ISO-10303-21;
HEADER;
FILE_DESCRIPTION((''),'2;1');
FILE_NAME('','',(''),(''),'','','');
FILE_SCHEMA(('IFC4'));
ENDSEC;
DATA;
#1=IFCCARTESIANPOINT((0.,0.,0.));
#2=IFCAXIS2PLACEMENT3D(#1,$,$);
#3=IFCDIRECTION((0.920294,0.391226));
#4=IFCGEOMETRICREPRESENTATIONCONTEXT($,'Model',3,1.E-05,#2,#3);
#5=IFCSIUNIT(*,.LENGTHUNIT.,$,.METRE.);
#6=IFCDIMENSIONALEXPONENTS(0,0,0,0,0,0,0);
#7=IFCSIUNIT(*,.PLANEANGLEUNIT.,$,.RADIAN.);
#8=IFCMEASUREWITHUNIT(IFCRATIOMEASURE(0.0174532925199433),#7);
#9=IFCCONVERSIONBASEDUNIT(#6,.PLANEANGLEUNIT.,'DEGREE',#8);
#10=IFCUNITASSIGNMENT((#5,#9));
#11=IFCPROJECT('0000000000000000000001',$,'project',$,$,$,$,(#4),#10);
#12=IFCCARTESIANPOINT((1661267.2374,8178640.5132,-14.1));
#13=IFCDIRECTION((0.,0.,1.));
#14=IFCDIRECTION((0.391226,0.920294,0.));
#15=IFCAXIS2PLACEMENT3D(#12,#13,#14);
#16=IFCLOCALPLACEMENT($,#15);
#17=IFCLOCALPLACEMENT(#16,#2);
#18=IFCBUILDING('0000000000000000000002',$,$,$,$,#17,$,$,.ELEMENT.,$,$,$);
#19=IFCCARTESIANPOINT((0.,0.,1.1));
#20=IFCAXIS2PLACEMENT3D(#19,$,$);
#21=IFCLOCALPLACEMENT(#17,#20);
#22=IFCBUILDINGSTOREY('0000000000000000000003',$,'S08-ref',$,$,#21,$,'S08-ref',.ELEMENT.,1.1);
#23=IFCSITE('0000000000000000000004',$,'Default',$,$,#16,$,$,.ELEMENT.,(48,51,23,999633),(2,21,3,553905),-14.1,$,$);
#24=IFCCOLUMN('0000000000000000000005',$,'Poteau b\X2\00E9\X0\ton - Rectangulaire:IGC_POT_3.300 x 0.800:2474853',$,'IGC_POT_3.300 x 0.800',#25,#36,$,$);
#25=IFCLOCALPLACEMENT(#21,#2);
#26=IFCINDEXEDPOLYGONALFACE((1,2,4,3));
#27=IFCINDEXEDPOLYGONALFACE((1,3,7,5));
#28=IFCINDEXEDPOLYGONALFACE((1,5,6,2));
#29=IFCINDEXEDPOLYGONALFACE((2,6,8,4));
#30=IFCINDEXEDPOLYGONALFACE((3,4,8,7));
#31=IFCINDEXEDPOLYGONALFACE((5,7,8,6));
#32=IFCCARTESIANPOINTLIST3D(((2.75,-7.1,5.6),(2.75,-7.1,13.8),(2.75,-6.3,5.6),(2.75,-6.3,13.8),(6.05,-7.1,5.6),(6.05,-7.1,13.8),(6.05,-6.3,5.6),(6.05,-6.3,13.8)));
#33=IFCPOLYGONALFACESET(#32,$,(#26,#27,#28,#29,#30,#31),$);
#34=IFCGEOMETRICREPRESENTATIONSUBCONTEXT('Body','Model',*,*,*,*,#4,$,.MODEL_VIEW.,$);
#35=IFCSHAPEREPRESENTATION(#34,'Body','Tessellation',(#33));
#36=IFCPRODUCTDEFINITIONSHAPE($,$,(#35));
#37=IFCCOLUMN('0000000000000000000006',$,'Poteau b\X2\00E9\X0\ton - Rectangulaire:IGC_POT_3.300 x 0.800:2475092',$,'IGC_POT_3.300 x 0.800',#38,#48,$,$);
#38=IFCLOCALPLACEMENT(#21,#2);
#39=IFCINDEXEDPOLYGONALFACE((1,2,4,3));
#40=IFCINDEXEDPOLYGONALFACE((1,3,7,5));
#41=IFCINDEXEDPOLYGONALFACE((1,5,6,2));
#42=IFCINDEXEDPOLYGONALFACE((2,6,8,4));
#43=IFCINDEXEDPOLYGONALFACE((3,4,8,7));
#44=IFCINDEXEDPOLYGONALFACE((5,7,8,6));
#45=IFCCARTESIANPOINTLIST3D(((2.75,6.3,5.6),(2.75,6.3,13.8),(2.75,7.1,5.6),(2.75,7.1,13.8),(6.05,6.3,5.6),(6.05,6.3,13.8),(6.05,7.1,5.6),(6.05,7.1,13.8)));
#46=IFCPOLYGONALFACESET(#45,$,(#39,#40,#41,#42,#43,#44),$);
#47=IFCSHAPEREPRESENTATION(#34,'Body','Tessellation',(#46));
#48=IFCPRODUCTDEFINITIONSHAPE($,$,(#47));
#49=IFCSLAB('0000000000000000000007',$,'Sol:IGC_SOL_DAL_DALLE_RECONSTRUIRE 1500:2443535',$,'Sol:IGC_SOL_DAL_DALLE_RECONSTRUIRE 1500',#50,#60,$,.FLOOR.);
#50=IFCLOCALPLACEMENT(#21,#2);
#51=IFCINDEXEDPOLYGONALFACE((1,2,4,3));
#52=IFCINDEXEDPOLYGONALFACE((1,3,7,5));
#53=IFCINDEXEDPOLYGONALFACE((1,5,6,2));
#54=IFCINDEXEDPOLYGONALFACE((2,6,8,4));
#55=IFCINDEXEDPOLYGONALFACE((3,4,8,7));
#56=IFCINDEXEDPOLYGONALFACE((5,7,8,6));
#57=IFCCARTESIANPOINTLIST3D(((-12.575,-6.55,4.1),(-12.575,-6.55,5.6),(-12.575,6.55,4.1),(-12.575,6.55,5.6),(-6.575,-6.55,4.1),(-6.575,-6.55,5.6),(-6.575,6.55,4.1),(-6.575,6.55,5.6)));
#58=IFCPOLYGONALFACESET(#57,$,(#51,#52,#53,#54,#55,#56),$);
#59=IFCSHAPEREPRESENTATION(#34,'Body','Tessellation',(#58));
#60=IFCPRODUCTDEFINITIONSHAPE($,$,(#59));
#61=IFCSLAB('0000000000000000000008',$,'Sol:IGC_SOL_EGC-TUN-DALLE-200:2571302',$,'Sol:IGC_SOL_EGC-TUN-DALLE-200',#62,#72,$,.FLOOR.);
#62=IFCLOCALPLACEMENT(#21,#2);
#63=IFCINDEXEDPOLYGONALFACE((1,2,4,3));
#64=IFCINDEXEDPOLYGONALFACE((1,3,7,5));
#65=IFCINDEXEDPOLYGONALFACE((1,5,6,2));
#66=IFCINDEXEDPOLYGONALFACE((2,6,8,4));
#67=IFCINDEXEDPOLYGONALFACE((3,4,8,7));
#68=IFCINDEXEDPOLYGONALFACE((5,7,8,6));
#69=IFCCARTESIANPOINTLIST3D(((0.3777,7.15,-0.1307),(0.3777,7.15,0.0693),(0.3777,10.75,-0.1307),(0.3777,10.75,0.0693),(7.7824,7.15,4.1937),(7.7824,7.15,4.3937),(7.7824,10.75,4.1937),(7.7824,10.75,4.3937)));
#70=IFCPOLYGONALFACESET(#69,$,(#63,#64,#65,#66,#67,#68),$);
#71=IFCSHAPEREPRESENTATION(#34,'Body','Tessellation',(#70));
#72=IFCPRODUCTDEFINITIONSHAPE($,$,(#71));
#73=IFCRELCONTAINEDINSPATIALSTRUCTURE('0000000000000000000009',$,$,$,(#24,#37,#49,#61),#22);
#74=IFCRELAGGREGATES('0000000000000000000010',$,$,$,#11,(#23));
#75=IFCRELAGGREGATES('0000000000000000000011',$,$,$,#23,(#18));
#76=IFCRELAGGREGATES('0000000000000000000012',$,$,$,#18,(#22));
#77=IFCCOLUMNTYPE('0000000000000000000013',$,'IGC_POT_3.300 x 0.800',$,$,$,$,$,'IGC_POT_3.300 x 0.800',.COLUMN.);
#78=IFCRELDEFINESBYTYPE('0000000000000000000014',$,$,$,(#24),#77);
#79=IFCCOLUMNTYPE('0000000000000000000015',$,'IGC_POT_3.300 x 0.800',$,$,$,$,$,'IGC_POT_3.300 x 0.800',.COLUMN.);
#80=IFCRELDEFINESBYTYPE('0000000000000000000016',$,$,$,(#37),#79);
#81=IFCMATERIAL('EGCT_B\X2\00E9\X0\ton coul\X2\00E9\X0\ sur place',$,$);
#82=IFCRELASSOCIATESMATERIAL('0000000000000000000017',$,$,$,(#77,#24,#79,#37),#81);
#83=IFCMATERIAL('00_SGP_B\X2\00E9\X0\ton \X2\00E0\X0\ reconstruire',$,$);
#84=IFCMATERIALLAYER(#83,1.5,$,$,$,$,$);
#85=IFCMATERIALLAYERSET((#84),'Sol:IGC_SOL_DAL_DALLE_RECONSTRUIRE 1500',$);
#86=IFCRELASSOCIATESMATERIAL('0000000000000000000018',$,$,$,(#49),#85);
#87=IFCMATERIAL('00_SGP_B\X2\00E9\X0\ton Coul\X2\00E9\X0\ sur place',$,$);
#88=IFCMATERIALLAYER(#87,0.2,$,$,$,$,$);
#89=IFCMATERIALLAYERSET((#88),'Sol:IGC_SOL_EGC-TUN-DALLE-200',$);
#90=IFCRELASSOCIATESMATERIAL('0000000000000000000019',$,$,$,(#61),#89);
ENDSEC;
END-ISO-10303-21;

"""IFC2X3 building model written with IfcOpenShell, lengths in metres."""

from ifc_helpers import new_model, entity, si_unit, converted_unit, direction, frame, frame_2d, origin, origin_2d_with_axis, place, context, subcontext, project, spatial, polyline, rectangle, outline, extrude, clip, halfspace, source, transform, mapped, material, layer, layer_set, layer_usage, type_object, type_shapes, element, save


model = new_model("IFC2X3")

# Units and contexts
model_context = context("Model", 3, precision=1e-05, world=origin(), true_north=direction((0.920294, 0.391226)))
body_context = subcontext(model_context, "Body", "Model", "MODEL_VIEW")
ifc_project = project(units=[si_unit("LENGTHUNIT", "METRE"), converted_unit("PLANEANGLEUNIT", "DEGREE", entity("IfcRatioMeasure", 0.0174532925199433), si_unit("PLANEANGLEUNIT", "RADIAN"), dimensions=[0, 0, 0, 0, 0, 0, 0])], contexts=[model_context])

# Site, building, storey
site_placement = place(None, frame((1661267.2374, 8178640.5132, -14.1), z_axis=(0.0, 0.0, 1.0), x_axis=(0.391226, 0.920294, 0.0)))
site = spatial("IfcSite", under=ifc_project, at=site_placement, Name="Default", CompositionType="ELEMENT", RefLatitude=(48, 51, 23, 999633), RefLongitude=(2, 21, 3, 553905), RefElevation=-14.1)
building_placement = place(site_placement, origin())
building = spatial("IfcBuilding", under=site, at=building_placement, CompositionType="ELEMENT")
storey_placement = place(building_placement, frame((0.0, 0.0, 1.1)))
storey = spatial("IfcBuildingStorey", under=building, at=storey_placement, Name="S08-ref", LongName="S08-ref", CompositionType="ELEMENT", Elevation=1.1)

# Columns
ifc_material_1 = material(Name="EGCT_Béton coulé sur place")
column_type_1 = type_object("IfcColumnType", Name="IGC_POT_3.300 x 0.800", ElementType="IGC_POT_3.300 x 0.800", PredefinedType="COLUMN", material=ifc_material_1)
shared_shape_1 = source(origin(), body_context, "Body", "SweptSolid", [
    extrude(rectangle(XDim=0.8, YDim=3.3, at=frame_2d((0.0, 0.0), x_axis=(1.0, 0.0))), frame((4.4, -6.7, 6.7), z_axis=(0.0, 0.0, 1.0), x_axis=(0.0, -1.0, 0.0)), (0.0, 0.0, 1.0), 8.2),
])
type_shapes(column_type_1, [shared_shape_1])
column_1_placement = place(storey_placement, frame((0.0, 0.0, -1.1)))
element("IfcColumn", 1, at=column_1_placement, inside=storey, type_object=column_type_1, material=ifc_material_1, Name="Poteau béton - Rectangulaire:IGC_POT_3.300 x 0.800:2474853", ObjectType="IGC_POT_3.300 x 0.800", context=body_context, shape_type="MappedRepresentation", body=[
    mapped(shared_shape_1, transform((0.0, 0.0, 0.0), scale=1.0)),
])
column_type_2 = type_object("IfcColumnType", Name="IGC_POT_3.300 x 0.800", ElementType="IGC_POT_3.300 x 0.800", PredefinedType="COLUMN", material=ifc_material_1)
shared_shape_2 = source(origin(), body_context, "Body", "SweptSolid", [
    extrude(rectangle(XDim=0.8, YDim=3.3, at=origin_2d_with_axis()), frame((4.4, 6.7, 6.7), z_axis=(0.0, 0.0, 1.0), x_axis=(0.0, -1.0, 0.0)), (0.0, 0.0, 1.0), 8.2),
])
type_shapes(column_type_2, [shared_shape_2])
column_2_placement = place(storey_placement, frame((0.0, 0.0, -1.1)))
element("IfcColumn", 2, at=column_2_placement, inside=storey, type_object=column_type_2, material=ifc_material_1, Name="Poteau béton - Rectangulaire:IGC_POT_3.300 x 0.800:2475092", ObjectType="IGC_POT_3.300 x 0.800", context=body_context, shape_type="MappedRepresentation", body=[
    mapped(shared_shape_2, transform((0.0, 0.0, 0.0), scale=1.0)),
])

# Slabs
ifc_material_2 = material(Name="00_SGP_Béton à reconstruire")
ifc_layer_1 = layer(ifc_material_2, 1.5)
ifc_layer_set_1 = layer_set([ifc_layer_1], Name="Sol:IGC_SOL_DAL_DALLE_RECONSTRUIRE 1500")
ifc_layer_usage_1 = layer_usage(ifc_layer_set_1, "AXIS3", "POSITIVE", 0.0)
slab_1_placement = place(storey_placement, origin())
element("IfcSlab", 3, at=slab_1_placement, inside=storey, material=ifc_layer_usage_1, Name="Sol:IGC_SOL_DAL_DALLE_RECONSTRUIRE 1500:2443535", ObjectType="Sol:IGC_SOL_DAL_DALLE_RECONSTRUIRE 1500", PredefinedType="FLOOR", context=body_context, shape_type="SweptSolid", body=[
    extrude(outline(polyline([(-6.55, -3.0), (6.55, -3.0), (6.55, 3.0), (-6.55, 3.0), (-6.55, -3.0)])), frame((-9.575, 0.0, 5.6), z_axis=(0.0, 0.0, -1.0), x_axis=(0.0, 1.0, 0.0)), (0.0, 0.0, 1.0), 1.5),
])
ifc_material_3 = material(Name="00_SGP_Béton Coulé sur place")
ifc_layer_2 = layer(ifc_material_3, 0.2)
ifc_layer_set_2 = layer_set([ifc_layer_2], Name="Sol:IGC_SOL_EGC-TUN-DALLE-200")
ifc_layer_usage_2 = layer_usage(ifc_layer_set_2, "AXIS3", "POSITIVE", 0.0)
slab_2_placement = place(storey_placement, origin())
element("IfcSlab", 4, at=slab_2_placement, inside=storey, material=ifc_layer_usage_2, Name="Sol:IGC_SOL_EGC-TUN-DALLE-200:2571302", ObjectType="Sol:IGC_SOL_EGC-TUN-DALLE-200", PredefinedType="FLOOR", context=body_context, shape_type="Clipping", body=[
    clip(clip(extrude(rectangle(XDim=8.575, YDim=3.6, at=frame_2d((0.0, 0.0), x_axis=(0.0, 1.0))), frame((4.08, 8.95, 2.2315), z_axis=(0.504305, 0.0, -0.863525), x_axis=(0.0, 1.0, 0.0)), (0.0, -0.504305, 0.863525), 0.2316), halfspace(frame((4.08, 8.95, 2.0315), z_axis=(0.504305, 0.0, -0.863525), x_axis=(0.0, -1.0, 0.0)), False)), halfspace(frame((4.08, 8.95, 2.2315), z_axis=(-0.504305, 0.0, 0.863525), x_axis=(0.0, -1.0, 0.0)), False)),
])

save(model, "model.ifc")
